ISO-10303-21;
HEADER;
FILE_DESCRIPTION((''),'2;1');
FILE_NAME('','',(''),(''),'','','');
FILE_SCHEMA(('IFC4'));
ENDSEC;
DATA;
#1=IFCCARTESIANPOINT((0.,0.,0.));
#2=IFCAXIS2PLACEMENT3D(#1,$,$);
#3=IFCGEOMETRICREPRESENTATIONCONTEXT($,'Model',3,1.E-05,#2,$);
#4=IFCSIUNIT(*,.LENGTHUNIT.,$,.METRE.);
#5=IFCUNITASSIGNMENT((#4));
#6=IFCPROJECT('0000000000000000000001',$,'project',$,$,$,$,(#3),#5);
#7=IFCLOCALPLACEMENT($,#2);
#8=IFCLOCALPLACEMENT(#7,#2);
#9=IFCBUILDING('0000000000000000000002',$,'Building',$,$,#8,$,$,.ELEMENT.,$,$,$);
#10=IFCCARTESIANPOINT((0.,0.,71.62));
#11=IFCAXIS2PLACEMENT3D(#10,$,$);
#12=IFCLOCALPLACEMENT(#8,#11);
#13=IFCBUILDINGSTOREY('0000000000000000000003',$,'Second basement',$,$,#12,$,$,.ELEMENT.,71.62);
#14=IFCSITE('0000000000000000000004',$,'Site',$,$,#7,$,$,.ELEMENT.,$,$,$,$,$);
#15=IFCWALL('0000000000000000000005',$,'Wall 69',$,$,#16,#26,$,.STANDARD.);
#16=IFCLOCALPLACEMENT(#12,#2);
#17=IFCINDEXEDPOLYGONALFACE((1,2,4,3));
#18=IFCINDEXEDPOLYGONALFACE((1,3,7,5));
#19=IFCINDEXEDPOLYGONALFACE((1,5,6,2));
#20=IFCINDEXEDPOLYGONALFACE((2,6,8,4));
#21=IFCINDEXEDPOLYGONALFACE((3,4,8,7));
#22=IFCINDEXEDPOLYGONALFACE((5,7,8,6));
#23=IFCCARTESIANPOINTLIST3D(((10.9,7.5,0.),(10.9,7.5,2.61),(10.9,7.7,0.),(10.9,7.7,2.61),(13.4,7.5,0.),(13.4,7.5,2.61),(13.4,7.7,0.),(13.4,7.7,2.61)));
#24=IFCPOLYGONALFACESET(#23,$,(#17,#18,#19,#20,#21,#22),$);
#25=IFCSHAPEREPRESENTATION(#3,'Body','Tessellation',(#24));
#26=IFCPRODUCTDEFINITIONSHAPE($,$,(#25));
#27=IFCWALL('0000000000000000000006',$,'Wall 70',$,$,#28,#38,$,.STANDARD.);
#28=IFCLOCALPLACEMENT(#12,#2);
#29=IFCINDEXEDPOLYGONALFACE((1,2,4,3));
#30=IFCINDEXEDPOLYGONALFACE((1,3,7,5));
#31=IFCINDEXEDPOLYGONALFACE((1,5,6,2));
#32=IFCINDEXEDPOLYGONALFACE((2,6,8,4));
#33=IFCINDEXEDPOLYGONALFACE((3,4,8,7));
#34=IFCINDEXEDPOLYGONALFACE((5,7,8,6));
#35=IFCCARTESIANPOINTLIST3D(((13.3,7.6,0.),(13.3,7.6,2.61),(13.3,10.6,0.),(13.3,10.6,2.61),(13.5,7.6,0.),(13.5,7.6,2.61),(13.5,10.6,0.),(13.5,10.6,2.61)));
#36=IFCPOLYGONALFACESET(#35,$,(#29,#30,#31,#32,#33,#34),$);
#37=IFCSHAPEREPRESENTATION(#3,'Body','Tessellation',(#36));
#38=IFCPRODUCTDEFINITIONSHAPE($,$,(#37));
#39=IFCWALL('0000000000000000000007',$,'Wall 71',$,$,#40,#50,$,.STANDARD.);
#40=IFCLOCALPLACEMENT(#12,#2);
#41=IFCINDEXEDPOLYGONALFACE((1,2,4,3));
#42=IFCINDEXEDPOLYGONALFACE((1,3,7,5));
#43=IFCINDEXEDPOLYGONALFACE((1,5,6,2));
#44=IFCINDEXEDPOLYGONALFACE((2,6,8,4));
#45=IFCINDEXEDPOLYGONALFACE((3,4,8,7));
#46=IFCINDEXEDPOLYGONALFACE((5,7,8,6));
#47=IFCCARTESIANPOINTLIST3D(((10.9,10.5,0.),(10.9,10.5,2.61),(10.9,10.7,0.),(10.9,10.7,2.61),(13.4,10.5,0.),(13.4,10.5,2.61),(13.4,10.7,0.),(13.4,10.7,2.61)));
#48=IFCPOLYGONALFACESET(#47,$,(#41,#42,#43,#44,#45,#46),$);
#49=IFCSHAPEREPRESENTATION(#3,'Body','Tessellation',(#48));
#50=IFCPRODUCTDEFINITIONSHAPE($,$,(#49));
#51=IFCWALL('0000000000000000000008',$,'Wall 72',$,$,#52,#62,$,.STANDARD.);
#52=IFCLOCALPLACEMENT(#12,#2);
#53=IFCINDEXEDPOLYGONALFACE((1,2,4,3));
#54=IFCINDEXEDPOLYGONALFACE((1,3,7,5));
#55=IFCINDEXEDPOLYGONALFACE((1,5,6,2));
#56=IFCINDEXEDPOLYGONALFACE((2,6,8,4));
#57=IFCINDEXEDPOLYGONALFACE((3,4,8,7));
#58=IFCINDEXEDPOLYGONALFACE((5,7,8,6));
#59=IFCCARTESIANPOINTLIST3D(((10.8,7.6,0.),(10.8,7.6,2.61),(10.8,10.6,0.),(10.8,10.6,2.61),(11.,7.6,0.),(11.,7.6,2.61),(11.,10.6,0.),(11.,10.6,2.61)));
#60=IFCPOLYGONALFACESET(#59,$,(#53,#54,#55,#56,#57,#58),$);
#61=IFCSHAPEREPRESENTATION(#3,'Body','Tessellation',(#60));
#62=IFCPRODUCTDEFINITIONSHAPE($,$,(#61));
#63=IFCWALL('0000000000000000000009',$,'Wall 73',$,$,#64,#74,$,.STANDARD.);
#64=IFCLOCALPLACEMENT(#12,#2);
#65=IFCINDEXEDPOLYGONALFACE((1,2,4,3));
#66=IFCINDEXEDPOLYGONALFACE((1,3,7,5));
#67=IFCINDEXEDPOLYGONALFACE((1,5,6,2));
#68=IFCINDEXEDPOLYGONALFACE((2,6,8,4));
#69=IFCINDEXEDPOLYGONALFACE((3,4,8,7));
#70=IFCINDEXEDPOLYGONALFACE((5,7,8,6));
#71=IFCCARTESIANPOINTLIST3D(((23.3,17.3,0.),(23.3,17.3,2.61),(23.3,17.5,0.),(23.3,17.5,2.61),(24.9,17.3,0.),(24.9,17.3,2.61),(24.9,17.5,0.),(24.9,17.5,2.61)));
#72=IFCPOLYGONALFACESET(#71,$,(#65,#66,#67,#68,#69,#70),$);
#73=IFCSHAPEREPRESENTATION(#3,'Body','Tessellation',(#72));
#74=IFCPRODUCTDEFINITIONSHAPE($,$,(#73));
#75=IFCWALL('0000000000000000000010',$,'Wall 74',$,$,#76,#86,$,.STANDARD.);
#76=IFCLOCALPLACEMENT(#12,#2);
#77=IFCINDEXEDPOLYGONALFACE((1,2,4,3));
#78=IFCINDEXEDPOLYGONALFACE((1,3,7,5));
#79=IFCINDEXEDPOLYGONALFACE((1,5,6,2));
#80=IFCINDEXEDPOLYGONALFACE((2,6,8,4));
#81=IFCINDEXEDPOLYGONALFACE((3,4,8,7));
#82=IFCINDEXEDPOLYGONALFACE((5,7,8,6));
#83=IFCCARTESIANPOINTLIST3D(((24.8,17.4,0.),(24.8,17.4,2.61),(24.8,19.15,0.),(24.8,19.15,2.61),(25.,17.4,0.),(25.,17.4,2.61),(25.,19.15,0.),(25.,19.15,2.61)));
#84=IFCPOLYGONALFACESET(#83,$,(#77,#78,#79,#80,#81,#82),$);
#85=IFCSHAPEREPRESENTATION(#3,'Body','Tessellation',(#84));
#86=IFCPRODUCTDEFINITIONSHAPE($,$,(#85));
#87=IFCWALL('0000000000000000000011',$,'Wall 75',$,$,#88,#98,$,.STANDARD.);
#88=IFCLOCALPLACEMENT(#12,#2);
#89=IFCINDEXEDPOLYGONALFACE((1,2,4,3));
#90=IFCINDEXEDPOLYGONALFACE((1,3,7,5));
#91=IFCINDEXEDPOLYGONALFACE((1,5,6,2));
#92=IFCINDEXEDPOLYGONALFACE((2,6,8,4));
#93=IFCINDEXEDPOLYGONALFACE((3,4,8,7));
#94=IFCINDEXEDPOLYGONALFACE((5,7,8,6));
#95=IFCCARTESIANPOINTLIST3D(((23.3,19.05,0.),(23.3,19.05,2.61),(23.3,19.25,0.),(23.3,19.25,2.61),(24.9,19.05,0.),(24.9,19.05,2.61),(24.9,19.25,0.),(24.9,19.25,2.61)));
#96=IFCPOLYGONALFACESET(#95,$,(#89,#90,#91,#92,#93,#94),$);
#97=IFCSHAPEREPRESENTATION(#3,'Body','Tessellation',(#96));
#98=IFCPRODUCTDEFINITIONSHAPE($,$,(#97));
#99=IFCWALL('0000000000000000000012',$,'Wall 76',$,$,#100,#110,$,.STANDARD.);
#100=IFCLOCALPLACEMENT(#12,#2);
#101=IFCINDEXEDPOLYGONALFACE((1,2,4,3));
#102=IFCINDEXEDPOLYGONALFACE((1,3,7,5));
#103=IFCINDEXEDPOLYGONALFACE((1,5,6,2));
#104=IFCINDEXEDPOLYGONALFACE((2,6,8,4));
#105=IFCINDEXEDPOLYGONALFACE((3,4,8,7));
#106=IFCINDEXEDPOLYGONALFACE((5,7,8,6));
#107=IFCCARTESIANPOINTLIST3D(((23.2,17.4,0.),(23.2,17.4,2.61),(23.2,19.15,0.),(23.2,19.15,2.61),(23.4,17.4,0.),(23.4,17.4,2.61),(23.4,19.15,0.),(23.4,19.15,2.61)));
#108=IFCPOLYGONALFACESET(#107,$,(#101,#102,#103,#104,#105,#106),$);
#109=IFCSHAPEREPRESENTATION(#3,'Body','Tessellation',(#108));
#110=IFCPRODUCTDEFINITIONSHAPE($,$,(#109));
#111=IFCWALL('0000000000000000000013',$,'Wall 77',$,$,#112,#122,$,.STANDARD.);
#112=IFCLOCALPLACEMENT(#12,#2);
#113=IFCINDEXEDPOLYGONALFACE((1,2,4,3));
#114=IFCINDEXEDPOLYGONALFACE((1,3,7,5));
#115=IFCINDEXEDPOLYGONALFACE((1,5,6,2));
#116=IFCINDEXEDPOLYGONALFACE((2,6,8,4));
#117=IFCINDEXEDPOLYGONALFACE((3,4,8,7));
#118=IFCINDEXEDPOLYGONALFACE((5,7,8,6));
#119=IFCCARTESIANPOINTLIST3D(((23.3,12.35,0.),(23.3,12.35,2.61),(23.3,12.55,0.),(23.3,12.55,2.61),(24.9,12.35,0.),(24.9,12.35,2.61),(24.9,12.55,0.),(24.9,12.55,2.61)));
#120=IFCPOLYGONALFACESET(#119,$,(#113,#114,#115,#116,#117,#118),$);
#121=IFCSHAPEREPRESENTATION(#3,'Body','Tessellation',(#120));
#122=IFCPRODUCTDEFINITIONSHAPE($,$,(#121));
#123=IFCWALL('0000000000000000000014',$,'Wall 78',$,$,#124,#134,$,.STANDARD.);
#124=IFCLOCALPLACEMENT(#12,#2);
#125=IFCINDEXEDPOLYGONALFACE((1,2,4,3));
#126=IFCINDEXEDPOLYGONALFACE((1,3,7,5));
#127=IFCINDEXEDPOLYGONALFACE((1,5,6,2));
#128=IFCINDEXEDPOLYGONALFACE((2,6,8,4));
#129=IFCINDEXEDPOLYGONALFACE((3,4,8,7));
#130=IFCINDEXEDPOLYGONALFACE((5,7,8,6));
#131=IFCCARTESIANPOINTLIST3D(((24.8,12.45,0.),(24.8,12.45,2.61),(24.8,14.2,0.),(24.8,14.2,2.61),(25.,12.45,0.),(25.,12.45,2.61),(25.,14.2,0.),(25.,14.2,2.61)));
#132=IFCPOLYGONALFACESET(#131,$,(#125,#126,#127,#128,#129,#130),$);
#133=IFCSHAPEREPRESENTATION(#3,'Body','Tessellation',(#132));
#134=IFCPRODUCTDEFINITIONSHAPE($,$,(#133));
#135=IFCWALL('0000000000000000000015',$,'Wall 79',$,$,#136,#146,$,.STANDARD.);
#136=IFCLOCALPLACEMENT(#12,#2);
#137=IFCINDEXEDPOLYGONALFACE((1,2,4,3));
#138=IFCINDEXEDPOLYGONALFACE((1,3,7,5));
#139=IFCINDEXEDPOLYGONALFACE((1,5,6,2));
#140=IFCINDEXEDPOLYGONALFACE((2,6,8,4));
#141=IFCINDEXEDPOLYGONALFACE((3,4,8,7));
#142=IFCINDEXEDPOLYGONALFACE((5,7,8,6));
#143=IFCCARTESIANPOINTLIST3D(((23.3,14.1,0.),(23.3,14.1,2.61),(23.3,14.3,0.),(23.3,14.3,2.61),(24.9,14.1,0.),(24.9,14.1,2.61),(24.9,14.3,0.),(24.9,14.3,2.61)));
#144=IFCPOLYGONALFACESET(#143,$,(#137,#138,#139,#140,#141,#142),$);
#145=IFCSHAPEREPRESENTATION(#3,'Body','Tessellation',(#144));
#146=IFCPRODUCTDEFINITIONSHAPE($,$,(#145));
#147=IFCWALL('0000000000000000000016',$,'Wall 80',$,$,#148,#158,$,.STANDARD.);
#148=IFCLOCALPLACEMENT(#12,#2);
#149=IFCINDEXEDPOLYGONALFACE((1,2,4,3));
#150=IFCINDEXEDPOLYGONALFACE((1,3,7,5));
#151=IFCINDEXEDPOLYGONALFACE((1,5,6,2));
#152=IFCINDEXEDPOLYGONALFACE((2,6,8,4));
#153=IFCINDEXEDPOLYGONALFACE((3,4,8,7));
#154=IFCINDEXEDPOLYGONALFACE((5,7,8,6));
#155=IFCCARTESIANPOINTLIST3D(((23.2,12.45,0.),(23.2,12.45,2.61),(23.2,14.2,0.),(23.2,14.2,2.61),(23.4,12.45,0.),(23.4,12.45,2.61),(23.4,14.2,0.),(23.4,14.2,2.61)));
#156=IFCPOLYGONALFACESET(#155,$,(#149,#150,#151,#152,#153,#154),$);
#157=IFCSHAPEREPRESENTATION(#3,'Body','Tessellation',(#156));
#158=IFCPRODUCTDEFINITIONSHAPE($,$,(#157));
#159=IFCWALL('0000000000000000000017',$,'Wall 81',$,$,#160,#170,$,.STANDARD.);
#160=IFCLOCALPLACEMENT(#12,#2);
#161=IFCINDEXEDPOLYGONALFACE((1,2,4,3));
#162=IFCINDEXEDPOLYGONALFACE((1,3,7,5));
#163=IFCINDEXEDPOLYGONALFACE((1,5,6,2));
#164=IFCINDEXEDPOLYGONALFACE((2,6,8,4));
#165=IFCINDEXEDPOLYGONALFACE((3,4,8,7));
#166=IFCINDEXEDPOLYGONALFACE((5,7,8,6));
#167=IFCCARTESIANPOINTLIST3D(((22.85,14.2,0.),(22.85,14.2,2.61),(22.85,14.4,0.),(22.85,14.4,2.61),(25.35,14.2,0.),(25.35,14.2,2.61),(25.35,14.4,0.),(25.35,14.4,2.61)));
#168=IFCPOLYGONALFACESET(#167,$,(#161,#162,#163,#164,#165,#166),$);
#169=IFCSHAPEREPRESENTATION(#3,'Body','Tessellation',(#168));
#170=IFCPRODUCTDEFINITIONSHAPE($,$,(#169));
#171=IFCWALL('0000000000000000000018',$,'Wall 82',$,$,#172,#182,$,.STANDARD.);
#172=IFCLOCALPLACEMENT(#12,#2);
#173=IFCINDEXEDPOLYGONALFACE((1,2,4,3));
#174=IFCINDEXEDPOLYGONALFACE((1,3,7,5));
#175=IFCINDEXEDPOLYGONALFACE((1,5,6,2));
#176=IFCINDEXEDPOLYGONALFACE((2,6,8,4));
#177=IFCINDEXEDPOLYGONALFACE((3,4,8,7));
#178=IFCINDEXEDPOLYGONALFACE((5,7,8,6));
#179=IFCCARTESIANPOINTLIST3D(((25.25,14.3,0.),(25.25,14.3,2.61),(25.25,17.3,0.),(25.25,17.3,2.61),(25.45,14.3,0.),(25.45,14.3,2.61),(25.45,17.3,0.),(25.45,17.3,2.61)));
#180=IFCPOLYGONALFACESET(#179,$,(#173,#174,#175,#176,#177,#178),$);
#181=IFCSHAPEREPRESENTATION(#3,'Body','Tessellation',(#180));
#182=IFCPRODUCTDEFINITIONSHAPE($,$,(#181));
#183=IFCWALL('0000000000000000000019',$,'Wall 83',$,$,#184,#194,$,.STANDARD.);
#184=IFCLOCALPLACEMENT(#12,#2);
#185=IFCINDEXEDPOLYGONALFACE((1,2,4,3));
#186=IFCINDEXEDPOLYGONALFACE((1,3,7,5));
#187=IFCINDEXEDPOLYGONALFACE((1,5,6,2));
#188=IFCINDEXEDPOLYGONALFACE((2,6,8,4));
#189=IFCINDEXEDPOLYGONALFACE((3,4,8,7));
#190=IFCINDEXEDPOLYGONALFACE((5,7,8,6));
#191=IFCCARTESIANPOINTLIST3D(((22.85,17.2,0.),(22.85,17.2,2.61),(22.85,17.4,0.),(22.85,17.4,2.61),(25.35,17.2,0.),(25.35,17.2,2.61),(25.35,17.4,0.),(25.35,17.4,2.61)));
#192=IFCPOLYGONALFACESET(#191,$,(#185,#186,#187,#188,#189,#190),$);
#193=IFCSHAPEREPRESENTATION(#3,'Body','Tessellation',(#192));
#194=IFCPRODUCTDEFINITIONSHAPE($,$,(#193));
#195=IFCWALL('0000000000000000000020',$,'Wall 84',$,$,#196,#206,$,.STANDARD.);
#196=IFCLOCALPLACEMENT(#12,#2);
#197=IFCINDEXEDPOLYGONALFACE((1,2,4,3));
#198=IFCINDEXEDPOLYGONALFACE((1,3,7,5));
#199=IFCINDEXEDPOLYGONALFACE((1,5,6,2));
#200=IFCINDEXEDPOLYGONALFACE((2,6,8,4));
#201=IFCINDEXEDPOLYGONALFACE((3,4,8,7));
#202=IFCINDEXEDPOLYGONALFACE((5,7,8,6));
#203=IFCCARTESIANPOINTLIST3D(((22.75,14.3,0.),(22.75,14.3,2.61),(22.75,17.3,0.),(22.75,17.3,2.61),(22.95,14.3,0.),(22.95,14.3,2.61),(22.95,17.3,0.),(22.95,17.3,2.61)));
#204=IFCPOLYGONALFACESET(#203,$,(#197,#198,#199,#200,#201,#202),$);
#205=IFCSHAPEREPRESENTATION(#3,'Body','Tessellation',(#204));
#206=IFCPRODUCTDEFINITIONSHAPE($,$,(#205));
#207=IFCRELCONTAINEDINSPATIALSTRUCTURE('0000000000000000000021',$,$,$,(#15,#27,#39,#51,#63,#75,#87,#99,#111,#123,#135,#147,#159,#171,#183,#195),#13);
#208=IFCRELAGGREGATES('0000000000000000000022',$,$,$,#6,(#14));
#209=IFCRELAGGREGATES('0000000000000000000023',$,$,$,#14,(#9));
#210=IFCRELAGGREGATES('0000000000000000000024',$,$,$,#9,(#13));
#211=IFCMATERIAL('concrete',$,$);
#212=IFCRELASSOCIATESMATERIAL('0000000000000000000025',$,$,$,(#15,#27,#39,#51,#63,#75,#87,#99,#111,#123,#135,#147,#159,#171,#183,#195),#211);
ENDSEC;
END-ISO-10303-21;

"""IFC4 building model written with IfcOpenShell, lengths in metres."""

from ifc_helpers import new_model, si_unit, frame, frame_2d, origin, place, context, project, spatial, rectangle, extrude, material, element, save


model = new_model("IFC4")

# Units and contexts
model_context = context("Model", 3, precision=1e-05, world=origin())
ifc_project = project(units=[si_unit("LENGTHUNIT", "METRE")], contexts=[model_context])

# Site, building, storey
site_placement = place(None, origin())
site = spatial("IfcSite", under=ifc_project, at=site_placement, Name="Site", CompositionType="ELEMENT")
building_placement = place(site_placement, origin())
building = spatial("IfcBuilding", under=site, at=building_placement, Name="Building", CompositionType="ELEMENT")
storey_placement = place(building_placement, frame((0.0, 0.0, 71.62)))
storey = spatial("IfcBuildingStorey", under=building, at=storey_placement, Name="Second basement", CompositionType="ELEMENT", Elevation=71.62)

# Shared definitions
ifc_material = material(Name="concrete")

# Walls
wall_1_placement = place(storey_placement, frame((10.9, 7.6, 0.0), z_axis=(0.0, 0.0, 1.0), x_axis=(1.0, 0.0, 0.0)))
element("IfcWall", 1, at=wall_1_placement, inside=storey, material=ifc_material, Name="Wall 69", PredefinedType="STANDARD", context=model_context, shape_type="SweptSolid", body=[
    extrude(rectangle(XDim=2.5, YDim=0.2, at=frame_2d((1.25, 0.0))), origin(), (0.0, 0.0, 1.0), 2.61),
])
wall_2_placement = place(storey_placement, frame((13.4, 7.6, 0.0), z_axis=(0.0, 0.0, 1.0), x_axis=(0.0, 1.0, 0.0)))
element("IfcWall", 2, at=wall_2_placement, inside=storey, material=ifc_material, Name="Wall 70", PredefinedType="STANDARD", context=model_context, shape_type="SweptSolid", body=[
    extrude(rectangle(XDim=3.0, YDim=0.2, at=frame_2d((1.5, 0.0))), origin(), (0.0, 0.0, 1.0), 2.61),
])
wall_3_placement = place(storey_placement, frame((13.4, 10.6, 0.0), z_axis=(0.0, 0.0, 1.0), x_axis=(-1.0, 0.0, 0.0)))
element("IfcWall", 3, at=wall_3_placement, inside=storey, material=ifc_material, Name="Wall 71", PredefinedType="STANDARD", context=model_context, shape_type="SweptSolid", body=[
    extrude(rectangle(XDim=2.5, YDim=0.2, at=frame_2d((1.25, 0.0))), origin(), (0.0, 0.0, 1.0), 2.61),
])
wall_4_placement = place(storey_placement, frame((10.9, 10.6, 0.0), z_axis=(0.0, 0.0, 1.0), x_axis=(0.0, -1.0, 0.0)))
element("IfcWall", 4, at=wall_4_placement, inside=storey, material=ifc_material, Name="Wall 72", PredefinedType="STANDARD", context=model_context, shape_type="SweptSolid", body=[
    extrude(rectangle(XDim=3.0, YDim=0.2, at=frame_2d((1.5, 0.0))), origin(), (0.0, 0.0, 1.0), 2.61),
])
wall_5_placement = place(storey_placement, frame((23.3, 17.4, 0.0), z_axis=(0.0, 0.0, 1.0), x_axis=(1.0, 0.0, 0.0)))
element("IfcWall", 5, at=wall_5_placement, inside=storey, material=ifc_material, Name="Wall 73", PredefinedType="STANDARD", context=model_context, shape_type="SweptSolid", body=[
    extrude(rectangle(XDim=1.6, YDim=0.2, at=frame_2d((0.8, 0.0))), origin(), (0.0, 0.0, 1.0), 2.61),
])
wall_6_placement = place(storey_placement, frame((24.9, 17.4, 0.0), z_axis=(0.0, 0.0, 1.0), x_axis=(0.0, 1.0, 0.0)))
element("IfcWall", 6, at=wall_6_placement, inside=storey, material=ifc_material, Name="Wall 74", PredefinedType="STANDARD", context=model_context, shape_type="SweptSolid", body=[
    extrude(rectangle(XDim=1.75, YDim=0.2, at=frame_2d((0.875, 0.0))), origin(), (0.0, 0.0, 1.0), 2.61),
])
wall_7_placement = place(storey_placement, frame((24.9, 19.15, 0.0), z_axis=(0.0, 0.0, 1.0), x_axis=(-1.0, 0.0, 0.0)))
element("IfcWall", 7, at=wall_7_placement, inside=storey, material=ifc_material, Name="Wall 75", PredefinedType="STANDARD", context=model_context, shape_type="SweptSolid", body=[
    extrude(rectangle(XDim=1.6, YDim=0.2, at=frame_2d((0.8, 0.0))), origin(), (0.0, 0.0, 1.0), 2.61),
])
wall_8_placement = place(storey_placement, frame((23.3, 19.15, 0.0), z_axis=(0.0, 0.0, 1.0), x_axis=(0.0, -1.0, 0.0)))
element("IfcWall", 8, at=wall_8_placement, inside=storey, material=ifc_material, Name="Wall 76", PredefinedType="STANDARD", context=model_context, shape_type="SweptSolid", body=[
    extrude(rectangle(XDim=1.75, YDim=0.2, at=frame_2d((0.875, 0.0))), origin(), (0.0, 0.0, 1.0), 2.61),
])
wall_9_placement = place(storey_placement, frame((23.3, 12.45, 0.0), z_axis=(0.0, 0.0, 1.0), x_axis=(1.0, 0.0, 0.0)))
element("IfcWall", 9, at=wall_9_placement, inside=storey, material=ifc_material, Name="Wall 77", PredefinedType="STANDARD", context=model_context, shape_type="SweptSolid", body=[
    extrude(rectangle(XDim=1.6, YDim=0.2, at=frame_2d((0.8, 0.0))), origin(), (0.0, 0.0, 1.0), 2.61),
])
wall_10_placement = place(storey_placement, frame((24.9, 12.45, 0.0), z_axis=(0.0, 0.0, 1.0), x_axis=(0.0, 1.0, 0.0)))
element("IfcWall", 10, at=wall_10_placement, inside=storey, material=ifc_material, Name="Wall 78", PredefinedType="STANDARD", context=model_context, shape_type="SweptSolid", body=[
    extrude(rectangle(XDim=1.75, YDim=0.2, at=frame_2d((0.875, 0.0))), origin(), (0.0, 0.0, 1.0), 2.61),
])
wall_11_placement = place(storey_placement, frame((24.9, 14.2, 0.0), z_axis=(0.0, 0.0, 1.0), x_axis=(-1.0, 0.0, 0.0)))
element("IfcWall", 11, at=wall_11_placement, inside=storey, material=ifc_material, Name="Wall 79", PredefinedType="STANDARD", context=model_context, shape_type="SweptSolid", body=[
    extrude(rectangle(XDim=1.6, YDim=0.2, at=frame_2d((0.8, 0.0))), origin(), (0.0, 0.0, 1.0), 2.61),
])
wall_12_placement = place(storey_placement, frame((23.3, 14.2, 0.0), z_axis=(0.0, 0.0, 1.0), x_axis=(0.0, -1.0, 0.0)))
element("IfcWall", 12, at=wall_12_placement, inside=storey, material=ifc_material, Name="Wall 80", PredefinedType="STANDARD", context=model_context, shape_type="SweptSolid", body=[
    extrude(rectangle(XDim=1.75, YDim=0.2, at=frame_2d((0.875, 0.0))), origin(), (0.0, 0.0, 1.0), 2.61),
])
wall_13_placement = place(storey_placement, frame((22.85, 14.3, 0.0), z_axis=(0.0, 0.0, 1.0), x_axis=(1.0, 0.0, 0.0)))
element("IfcWall", 13, at=wall_13_placement, inside=storey, material=ifc_material, Name="Wall 81", PredefinedType="STANDARD", context=model_context, shape_type="SweptSolid", body=[
    extrude(rectangle(XDim=2.5, YDim=0.2, at=frame_2d((1.25, 0.0))), origin(), (0.0, 0.0, 1.0), 2.61),
])
wall_14_placement = place(storey_placement, frame((25.35, 14.3, 0.0), z_axis=(0.0, 0.0, 1.0), x_axis=(0.0, 1.0, 0.0)))
element("IfcWall", 14, at=wall_14_placement, inside=storey, material=ifc_material, Name="Wall 82", PredefinedType="STANDARD", context=model_context, shape_type="SweptSolid", body=[
    extrude(rectangle(XDim=3.0, YDim=0.2, at=frame_2d((1.5, 0.0))), origin(), (0.0, 0.0, 1.0), 2.61),
])
wall_15_placement = place(storey_placement, frame((25.35, 17.3, 0.0), z_axis=(0.0, 0.0, 1.0), x_axis=(-1.0, 0.0, 0.0)))
element("IfcWall", 15, at=wall_15_placement, inside=storey, material=ifc_material, Name="Wall 83", PredefinedType="STANDARD", context=model_context, shape_type="SweptSolid", body=[
    extrude(rectangle(XDim=2.5, YDim=0.2, at=frame_2d((1.25, 0.0))), origin(), (0.0, 0.0, 1.0), 2.61),
])
wall_16_placement = place(storey_placement, frame((22.85, 17.3, 0.0), z_axis=(0.0, 0.0, 1.0), x_axis=(0.0, -1.0, 0.0)))
element("IfcWall", 16, at=wall_16_placement, inside=storey, material=ifc_material, Name="Wall 84", PredefinedType="STANDARD", context=model_context, shape_type="SweptSolid", body=[
    extrude(rectangle(XDim=3.0, YDim=0.2, at=frame_2d((1.5, 0.0))), origin(), (0.0, 0.0, 1.0), 2.61),
])

save(model, "model.ifc")
